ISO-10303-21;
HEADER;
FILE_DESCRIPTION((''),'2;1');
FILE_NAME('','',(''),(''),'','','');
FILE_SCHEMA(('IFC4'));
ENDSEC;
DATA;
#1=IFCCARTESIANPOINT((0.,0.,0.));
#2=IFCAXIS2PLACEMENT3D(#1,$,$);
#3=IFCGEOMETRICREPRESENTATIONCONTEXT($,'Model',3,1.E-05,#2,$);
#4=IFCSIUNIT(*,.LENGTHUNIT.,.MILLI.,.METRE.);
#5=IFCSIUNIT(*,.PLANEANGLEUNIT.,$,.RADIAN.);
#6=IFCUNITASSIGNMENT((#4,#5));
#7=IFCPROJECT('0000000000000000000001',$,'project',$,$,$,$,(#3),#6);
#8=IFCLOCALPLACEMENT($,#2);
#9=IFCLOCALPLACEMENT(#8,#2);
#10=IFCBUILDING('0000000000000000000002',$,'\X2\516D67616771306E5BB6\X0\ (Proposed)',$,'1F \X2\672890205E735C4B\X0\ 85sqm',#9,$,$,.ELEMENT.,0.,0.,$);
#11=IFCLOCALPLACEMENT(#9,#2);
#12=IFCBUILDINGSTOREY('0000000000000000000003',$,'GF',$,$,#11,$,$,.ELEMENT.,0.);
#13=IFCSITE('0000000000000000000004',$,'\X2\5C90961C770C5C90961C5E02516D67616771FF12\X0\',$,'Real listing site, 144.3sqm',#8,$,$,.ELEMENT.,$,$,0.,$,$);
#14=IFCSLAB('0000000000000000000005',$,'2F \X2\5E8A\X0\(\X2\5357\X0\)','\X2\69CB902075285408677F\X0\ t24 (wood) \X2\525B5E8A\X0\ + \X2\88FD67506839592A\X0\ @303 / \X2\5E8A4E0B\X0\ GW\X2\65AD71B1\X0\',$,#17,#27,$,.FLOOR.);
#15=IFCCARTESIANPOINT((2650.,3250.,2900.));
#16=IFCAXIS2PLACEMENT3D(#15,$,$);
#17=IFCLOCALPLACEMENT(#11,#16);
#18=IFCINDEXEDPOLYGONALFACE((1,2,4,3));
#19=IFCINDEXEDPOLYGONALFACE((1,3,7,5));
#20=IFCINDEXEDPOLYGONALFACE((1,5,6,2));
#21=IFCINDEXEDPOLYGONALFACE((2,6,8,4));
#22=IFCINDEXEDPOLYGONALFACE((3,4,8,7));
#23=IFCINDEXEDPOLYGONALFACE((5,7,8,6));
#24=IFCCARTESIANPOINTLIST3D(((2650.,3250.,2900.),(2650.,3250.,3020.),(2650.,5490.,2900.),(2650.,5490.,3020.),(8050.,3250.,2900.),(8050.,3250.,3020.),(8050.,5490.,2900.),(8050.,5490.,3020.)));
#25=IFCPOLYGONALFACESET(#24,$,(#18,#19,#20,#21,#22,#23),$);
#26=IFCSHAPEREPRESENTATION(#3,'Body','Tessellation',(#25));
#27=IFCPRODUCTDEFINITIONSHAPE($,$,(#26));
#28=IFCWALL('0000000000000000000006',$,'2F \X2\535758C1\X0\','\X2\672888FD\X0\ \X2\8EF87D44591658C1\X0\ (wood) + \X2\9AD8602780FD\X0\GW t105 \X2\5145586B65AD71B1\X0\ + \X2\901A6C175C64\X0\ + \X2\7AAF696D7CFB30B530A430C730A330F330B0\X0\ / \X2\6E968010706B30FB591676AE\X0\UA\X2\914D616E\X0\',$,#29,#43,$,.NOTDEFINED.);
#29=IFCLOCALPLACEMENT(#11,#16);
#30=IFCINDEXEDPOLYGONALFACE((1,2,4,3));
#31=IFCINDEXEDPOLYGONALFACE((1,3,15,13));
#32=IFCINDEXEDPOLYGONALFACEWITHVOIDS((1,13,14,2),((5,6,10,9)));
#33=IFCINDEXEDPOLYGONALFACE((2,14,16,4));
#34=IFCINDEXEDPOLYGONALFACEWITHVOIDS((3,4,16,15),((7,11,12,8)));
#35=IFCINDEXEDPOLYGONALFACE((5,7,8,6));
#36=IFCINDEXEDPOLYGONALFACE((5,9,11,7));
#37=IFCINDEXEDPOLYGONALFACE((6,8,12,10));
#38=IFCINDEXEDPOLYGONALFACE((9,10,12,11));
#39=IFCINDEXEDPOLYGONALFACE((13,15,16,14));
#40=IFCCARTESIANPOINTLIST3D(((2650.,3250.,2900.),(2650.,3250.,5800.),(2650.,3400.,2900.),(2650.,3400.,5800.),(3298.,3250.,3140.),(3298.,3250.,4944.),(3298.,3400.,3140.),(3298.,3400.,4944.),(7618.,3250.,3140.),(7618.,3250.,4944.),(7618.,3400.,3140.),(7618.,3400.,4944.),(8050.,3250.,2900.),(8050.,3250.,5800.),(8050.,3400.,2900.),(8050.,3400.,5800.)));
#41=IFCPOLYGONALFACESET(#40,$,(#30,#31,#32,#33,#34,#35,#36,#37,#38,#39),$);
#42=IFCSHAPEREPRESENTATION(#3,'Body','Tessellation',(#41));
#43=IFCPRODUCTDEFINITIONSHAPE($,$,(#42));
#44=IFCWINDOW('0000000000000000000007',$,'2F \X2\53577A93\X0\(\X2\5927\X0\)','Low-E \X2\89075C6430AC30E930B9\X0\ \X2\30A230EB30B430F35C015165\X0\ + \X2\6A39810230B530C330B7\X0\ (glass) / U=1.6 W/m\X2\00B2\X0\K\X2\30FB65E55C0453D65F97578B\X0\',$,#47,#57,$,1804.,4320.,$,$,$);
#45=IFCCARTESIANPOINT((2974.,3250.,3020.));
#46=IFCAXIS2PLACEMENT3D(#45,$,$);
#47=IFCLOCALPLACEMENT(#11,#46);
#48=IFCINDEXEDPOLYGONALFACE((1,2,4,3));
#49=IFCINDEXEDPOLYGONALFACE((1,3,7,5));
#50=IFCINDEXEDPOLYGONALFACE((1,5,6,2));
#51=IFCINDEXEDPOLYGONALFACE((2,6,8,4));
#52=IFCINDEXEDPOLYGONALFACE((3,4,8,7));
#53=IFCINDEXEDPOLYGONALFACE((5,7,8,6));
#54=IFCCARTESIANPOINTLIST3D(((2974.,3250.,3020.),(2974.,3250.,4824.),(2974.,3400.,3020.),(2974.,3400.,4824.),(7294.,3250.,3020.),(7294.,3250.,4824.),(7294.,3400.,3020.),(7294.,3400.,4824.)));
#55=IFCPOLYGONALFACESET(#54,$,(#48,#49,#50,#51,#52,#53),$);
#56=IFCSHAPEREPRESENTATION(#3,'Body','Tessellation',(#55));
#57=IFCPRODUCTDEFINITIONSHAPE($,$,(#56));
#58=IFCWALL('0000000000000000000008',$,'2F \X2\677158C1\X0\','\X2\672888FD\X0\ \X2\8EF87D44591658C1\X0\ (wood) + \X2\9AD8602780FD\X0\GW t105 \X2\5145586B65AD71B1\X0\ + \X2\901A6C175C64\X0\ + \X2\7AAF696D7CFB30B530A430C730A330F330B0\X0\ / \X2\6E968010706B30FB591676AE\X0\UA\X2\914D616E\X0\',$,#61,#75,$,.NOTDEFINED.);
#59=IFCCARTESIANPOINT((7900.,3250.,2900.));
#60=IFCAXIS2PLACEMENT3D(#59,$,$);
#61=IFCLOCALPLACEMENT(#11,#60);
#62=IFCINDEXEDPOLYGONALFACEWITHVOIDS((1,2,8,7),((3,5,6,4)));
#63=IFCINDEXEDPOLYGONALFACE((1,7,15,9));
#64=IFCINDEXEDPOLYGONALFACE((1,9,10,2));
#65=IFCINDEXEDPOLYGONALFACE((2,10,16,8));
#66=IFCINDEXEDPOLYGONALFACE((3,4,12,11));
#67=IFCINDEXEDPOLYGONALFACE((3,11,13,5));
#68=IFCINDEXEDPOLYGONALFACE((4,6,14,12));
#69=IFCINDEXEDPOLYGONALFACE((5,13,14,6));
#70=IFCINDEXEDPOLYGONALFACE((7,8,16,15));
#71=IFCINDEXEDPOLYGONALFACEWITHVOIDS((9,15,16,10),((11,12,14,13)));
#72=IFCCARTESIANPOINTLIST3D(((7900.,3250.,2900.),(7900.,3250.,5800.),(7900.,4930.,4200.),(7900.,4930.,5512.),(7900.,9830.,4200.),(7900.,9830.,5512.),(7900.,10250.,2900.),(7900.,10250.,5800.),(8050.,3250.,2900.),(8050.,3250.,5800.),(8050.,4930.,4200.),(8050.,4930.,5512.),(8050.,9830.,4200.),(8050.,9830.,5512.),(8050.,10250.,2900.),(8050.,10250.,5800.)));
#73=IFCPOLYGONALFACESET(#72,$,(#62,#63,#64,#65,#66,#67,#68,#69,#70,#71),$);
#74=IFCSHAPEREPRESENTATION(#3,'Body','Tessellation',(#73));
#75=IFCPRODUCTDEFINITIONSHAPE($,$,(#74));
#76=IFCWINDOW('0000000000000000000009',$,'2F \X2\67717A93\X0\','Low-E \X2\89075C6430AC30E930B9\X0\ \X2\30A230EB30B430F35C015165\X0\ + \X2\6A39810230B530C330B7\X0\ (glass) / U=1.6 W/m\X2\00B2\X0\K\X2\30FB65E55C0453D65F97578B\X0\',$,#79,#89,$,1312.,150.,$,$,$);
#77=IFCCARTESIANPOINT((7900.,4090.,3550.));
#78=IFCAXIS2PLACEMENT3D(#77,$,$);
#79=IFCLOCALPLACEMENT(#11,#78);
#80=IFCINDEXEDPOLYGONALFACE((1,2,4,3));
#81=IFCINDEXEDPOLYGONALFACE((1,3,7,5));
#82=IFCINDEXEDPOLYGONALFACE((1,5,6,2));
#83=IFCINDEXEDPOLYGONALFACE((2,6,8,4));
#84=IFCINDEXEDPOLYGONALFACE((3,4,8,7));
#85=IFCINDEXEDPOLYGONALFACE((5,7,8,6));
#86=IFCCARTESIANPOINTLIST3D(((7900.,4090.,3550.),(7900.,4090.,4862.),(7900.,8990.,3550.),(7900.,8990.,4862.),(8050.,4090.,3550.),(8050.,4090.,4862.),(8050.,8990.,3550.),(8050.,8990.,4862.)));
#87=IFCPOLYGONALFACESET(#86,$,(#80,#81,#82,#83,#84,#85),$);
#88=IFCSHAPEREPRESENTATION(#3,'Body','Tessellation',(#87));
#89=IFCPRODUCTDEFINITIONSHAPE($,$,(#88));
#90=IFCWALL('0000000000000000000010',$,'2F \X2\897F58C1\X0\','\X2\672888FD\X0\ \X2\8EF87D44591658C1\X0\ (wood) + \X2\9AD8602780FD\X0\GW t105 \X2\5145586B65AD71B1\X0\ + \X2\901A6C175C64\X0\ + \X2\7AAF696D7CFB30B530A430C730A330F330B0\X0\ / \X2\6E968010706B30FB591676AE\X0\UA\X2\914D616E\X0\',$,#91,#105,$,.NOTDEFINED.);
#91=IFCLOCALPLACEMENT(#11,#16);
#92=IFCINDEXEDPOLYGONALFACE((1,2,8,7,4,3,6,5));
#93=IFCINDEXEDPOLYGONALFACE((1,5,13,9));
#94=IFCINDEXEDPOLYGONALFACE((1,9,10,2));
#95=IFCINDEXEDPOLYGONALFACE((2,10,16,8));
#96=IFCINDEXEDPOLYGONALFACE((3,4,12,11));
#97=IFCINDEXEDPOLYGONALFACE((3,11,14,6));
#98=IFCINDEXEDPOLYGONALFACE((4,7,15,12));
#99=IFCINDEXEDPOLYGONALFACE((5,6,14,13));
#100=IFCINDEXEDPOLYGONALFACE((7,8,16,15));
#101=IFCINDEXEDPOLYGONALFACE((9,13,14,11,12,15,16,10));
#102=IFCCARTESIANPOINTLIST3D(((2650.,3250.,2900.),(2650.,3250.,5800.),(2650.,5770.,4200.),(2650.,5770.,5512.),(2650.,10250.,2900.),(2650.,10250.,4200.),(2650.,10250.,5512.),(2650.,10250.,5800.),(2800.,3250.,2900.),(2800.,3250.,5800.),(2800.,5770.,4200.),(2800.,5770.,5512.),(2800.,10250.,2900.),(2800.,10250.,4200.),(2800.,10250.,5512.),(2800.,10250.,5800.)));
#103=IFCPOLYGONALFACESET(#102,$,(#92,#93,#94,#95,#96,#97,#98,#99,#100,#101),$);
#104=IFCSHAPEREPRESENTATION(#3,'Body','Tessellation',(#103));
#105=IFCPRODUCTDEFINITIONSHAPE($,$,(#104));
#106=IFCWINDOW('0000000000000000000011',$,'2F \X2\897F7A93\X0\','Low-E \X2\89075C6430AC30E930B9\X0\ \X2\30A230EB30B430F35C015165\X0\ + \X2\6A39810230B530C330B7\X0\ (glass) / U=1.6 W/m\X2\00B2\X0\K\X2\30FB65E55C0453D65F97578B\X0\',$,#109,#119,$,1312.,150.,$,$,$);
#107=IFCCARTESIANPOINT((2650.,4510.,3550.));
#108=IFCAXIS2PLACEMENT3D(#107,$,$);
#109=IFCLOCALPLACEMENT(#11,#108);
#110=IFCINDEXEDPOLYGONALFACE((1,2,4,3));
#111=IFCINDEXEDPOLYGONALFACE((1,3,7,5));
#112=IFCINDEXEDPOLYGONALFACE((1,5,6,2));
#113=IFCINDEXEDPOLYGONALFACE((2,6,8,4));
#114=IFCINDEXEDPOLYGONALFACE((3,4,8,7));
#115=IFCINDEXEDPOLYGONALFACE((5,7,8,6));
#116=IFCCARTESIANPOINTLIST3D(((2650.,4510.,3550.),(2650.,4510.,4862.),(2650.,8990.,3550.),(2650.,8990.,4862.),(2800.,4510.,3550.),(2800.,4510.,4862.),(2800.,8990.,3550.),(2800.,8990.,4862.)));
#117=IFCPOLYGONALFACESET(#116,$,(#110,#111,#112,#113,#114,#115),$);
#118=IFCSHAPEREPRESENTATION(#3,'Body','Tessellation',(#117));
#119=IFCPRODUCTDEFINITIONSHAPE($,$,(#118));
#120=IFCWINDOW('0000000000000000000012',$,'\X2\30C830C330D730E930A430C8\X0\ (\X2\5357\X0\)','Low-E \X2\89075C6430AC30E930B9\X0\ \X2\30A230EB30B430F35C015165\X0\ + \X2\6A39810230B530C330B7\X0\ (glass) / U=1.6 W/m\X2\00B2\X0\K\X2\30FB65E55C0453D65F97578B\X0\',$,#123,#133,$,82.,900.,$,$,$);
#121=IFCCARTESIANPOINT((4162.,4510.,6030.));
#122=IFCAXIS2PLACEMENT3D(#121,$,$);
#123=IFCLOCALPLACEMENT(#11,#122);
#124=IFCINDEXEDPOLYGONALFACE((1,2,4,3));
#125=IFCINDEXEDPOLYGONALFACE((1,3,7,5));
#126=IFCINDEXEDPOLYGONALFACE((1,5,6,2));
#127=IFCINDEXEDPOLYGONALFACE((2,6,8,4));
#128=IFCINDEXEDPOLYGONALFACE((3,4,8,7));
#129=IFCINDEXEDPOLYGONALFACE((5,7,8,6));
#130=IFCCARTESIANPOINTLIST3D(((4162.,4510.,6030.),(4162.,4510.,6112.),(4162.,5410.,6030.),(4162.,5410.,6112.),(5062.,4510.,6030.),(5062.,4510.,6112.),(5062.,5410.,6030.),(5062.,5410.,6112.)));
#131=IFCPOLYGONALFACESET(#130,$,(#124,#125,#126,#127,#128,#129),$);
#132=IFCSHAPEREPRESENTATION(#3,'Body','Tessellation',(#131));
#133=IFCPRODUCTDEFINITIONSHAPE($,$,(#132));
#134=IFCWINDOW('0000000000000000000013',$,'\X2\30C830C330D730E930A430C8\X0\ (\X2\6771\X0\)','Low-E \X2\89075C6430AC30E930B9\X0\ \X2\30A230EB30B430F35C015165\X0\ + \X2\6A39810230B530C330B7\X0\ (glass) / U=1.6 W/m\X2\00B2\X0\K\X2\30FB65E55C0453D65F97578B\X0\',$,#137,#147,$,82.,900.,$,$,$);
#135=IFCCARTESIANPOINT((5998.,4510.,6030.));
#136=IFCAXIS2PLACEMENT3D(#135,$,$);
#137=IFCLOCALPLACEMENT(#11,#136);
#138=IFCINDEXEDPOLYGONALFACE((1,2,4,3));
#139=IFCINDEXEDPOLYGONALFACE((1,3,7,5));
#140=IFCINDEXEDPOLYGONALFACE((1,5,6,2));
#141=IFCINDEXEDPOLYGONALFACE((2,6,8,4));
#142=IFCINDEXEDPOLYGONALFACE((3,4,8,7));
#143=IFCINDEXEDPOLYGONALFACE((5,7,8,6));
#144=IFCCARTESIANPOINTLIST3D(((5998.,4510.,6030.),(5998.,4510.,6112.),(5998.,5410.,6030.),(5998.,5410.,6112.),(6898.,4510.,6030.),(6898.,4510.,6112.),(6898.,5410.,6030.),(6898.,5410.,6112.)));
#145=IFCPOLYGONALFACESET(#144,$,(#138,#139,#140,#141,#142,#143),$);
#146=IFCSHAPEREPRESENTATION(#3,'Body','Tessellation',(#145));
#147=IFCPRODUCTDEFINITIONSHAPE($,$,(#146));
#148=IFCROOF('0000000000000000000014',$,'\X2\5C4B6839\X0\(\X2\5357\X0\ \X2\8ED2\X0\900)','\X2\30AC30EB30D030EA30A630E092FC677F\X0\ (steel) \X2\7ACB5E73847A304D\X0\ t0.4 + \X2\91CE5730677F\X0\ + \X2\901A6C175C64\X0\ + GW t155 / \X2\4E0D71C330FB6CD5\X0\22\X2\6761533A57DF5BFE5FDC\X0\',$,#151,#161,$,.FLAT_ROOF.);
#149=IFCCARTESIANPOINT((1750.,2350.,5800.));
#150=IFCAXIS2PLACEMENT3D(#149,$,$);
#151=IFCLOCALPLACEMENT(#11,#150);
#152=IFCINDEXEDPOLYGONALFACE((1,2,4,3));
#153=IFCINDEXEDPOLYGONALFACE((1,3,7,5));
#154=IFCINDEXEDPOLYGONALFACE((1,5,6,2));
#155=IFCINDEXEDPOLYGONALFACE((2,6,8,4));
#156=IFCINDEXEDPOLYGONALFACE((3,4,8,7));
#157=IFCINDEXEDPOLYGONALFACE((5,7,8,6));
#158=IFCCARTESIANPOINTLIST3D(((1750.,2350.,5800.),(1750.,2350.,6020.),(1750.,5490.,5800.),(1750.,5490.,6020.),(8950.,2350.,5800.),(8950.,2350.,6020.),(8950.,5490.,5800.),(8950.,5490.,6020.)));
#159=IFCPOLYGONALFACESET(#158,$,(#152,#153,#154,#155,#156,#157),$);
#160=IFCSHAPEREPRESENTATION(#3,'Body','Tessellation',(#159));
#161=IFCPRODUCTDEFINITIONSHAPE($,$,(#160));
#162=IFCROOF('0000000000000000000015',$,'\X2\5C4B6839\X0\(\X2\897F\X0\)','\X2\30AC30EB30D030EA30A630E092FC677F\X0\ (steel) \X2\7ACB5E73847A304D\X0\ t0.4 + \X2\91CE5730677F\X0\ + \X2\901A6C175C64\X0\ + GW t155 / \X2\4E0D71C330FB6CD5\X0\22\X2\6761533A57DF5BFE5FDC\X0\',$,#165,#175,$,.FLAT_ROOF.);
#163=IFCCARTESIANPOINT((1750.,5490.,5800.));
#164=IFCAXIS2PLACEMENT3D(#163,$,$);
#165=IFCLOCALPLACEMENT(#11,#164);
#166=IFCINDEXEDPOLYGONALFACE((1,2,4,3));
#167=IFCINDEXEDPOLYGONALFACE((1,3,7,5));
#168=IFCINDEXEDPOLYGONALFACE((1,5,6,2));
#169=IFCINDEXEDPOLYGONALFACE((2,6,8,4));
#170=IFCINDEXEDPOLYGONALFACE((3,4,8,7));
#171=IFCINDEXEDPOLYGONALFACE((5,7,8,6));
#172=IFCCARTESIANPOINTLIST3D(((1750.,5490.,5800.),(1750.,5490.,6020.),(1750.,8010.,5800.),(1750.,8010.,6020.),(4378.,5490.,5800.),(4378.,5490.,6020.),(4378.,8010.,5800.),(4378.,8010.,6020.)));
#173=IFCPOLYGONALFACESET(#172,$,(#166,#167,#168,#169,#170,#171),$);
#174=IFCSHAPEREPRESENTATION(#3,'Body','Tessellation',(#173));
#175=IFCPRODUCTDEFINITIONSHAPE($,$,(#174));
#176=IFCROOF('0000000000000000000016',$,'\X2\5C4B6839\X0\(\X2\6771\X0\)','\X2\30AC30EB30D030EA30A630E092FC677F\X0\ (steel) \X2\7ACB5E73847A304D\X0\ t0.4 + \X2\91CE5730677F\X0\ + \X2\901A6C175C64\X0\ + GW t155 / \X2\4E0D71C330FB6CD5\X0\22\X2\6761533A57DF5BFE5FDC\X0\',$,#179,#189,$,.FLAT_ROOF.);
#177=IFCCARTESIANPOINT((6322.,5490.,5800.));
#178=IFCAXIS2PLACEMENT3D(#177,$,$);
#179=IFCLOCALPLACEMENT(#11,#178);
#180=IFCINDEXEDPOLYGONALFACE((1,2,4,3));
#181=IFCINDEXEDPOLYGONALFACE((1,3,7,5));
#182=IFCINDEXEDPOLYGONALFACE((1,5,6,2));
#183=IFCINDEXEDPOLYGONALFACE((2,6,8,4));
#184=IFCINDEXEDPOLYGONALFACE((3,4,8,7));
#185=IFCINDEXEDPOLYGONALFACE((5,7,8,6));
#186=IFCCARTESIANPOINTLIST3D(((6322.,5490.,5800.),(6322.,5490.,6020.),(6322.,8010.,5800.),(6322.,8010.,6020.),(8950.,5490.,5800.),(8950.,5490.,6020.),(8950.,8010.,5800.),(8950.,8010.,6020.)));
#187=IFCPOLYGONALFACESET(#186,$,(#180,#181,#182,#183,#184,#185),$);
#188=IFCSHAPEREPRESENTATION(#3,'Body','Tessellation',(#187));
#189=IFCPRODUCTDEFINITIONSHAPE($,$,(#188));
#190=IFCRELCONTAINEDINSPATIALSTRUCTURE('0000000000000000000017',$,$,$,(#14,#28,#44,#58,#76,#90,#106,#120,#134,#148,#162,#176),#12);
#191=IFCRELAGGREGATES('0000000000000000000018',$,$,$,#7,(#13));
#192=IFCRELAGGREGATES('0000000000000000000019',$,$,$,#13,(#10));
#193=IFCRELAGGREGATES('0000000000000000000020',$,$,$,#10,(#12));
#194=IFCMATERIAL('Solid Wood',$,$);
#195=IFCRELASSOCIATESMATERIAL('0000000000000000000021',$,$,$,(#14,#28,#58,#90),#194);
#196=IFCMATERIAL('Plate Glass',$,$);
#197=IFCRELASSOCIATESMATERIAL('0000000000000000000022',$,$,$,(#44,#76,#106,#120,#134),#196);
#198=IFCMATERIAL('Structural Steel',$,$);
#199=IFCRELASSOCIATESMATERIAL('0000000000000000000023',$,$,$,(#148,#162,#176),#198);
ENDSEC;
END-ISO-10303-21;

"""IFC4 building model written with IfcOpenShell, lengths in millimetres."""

from ifc_helpers import new_model, si_unit, frame, frame_2d, origin, place, context, project, spatial, rectangle, extrude, material, element, fill, save


model = new_model("IFC4")

# Units and contexts
model_context = context("Model", 3, precision=1e-05, world=origin())
ifc_project = project(units=[si_unit("LENGTHUNIT", "METRE", prefix="MILLI"), si_unit("PLANEANGLEUNIT", "RADIAN")], contexts=[model_context])

# Site, building, storey
site_placement = place(None, origin())
site = spatial("IfcSite", under=ifc_project, at=site_placement, Name="岐阜県岐阜市六条東２", ObjectType="Real listing site, 144.3sqm", CompositionType="ELEMENT", RefElevation=0.0)
building_placement = place(site_placement, origin())
building = spatial("IfcBuilding", under=site, at=building_placement, Name="六条東の家 (Proposed)", ObjectType="1F 木造平屋 85sqm", CompositionType="ELEMENT", ElevationOfRefHeight=0.0, ElevationOfTerrain=0.0)
storey_placement = place(building_placement, origin())
storey = spatial("IfcBuildingStorey", under=building, at=storey_placement, Name="GF", CompositionType="ELEMENT", Elevation=0.0)

# Slab
ifc_material_1 = material(Name="Solid Wood")
slab_placement = place(storey_placement, frame((2650.0, 3250.0, 2900.0)))
element("IfcSlab", 1, at=slab_placement, inside=storey, material=ifc_material_1, Name="2F 床(南)", Description="構造用合板 t24 (wood) 剛床 + 製材根太 @303 / 床下 GW断熱", PredefinedType="FLOOR", context=model_context, shape_type="SweptSolid", body=[
    extrude(rectangle(XDim=5400.0, YDim=2240.0, at=frame_2d((2700.0, 1120.0))), frame((2650.0, 3250.0, 2900.0)), (0.0, 0.0, 1.0), 120.0),
])

# Walls, openings, windows
wall_1_placement = place(storey_placement, frame((2650.0, 3250.0, 2900.0)))
wall_1 = element("IfcWall", 2, at=wall_1_placement, inside=storey, material=ifc_material_1, Name="2F 南壁", Description="木製 軸組外壁 (wood) + 高性能GW t105 充填断熱 + 通気層 + 窯業系サイディング / 準耐火・外皮UA配慮", PredefinedType="NOTDEFINED", context=model_context, shape_type="SweptSolid", body=[
    extrude(rectangle(XDim=5400.0, YDim=150.0, at=frame_2d((2700.0, 75.0))), frame((2650.0, 3250.0, 2900.0)), (0.0, 0.0, 1.0), 2900.0),
])
opening_1_placement = place(storey_placement, frame((2974.0, 3250.0, 3020.0)))
opening_1 = element("IfcOpeningElement", 3, at=opening_1_placement, cuts=wall_1, PredefinedType="NOTDEFINED", context=model_context, shape_type="SweptSolid", body=[
    extrude(rectangle(XDim=4320.0, YDim=150.0, at=frame_2d((2160.0, 75.0))), frame((2974.0, 3250.0, 3020.0)), (0.0, 0.0, 1.0), 1804.0),
])
ifc_material_2 = material(Name="Plate Glass")
window_1_placement = place(storey_placement, frame((2974.0, 3250.0, 3020.0)))
window_1 = element("IfcWindow", 4, at=window_1_placement, inside=storey, material=ifc_material_2, Name="2F 南窓(大)", Description="Low-E 複層ガラス アルゴン封入 + 樹脂サッシ (glass) / U=1.6 W/m²K・日射取得型", OverallHeight=1804.0, OverallWidth=4320.0, context=model_context, shape_type="SweptSolid", body=[
    extrude(rectangle(XDim=4320.0, YDim=150.0, at=frame_2d((2160.0, 75.0))), frame((2974.0, 3250.0, 3020.0)), (0.0, 0.0, 1.0), 1804.0),
])
fill(opening_1, window_1)
wall_2_placement = place(storey_placement, frame((7900.0, 3250.0, 2900.0)))
wall_2 = element("IfcWall", 5, at=wall_2_placement, inside=storey, material=ifc_material_1, Name="2F 東壁", Description="木製 軸組外壁 (wood) + 高性能GW t105 充填断熱 + 通気層 + 窯業系サイディング / 準耐火・外皮UA配慮", PredefinedType="NOTDEFINED", context=model_context, shape_type="SweptSolid", body=[
    extrude(rectangle(XDim=150.0, YDim=7000.0, at=frame_2d((75.0, 3500.0))), frame((7900.0, 3250.0, 2900.0)), (0.0, 0.0, 1.0), 2900.0),
])
opening_2_placement = place(storey_placement, frame((7900.0, 4090.0, 3550.0)))
opening_2 = element("IfcOpeningElement", 6, at=opening_2_placement, cuts=wall_2, PredefinedType="NOTDEFINED", context=model_context, shape_type="SweptSolid", body=[
    extrude(rectangle(XDim=150.0, YDim=4900.0, at=frame_2d((75.0, 2450.0))), frame((7900.0, 4090.0, 3550.0)), (0.0, 0.0, 1.0), 1312.0),
])
window_2_placement = place(storey_placement, frame((7900.0, 4090.0, 3550.0)))
window_2 = element("IfcWindow", 7, at=window_2_placement, inside=storey, material=ifc_material_2, Name="2F 東窓", Description="Low-E 複層ガラス アルゴン封入 + 樹脂サッシ (glass) / U=1.6 W/m²K・日射取得型", OverallHeight=1312.0, OverallWidth=150.0, context=model_context, shape_type="SweptSolid", body=[
    extrude(rectangle(XDim=150.0, YDim=4900.0, at=frame_2d((75.0, 2450.0))), frame((7900.0, 4090.0, 3550.0)), (0.0, 0.0, 1.0), 1312.0),
])
fill(opening_2, window_2)
wall_3_placement = place(storey_placement, frame((2650.0, 3250.0, 2900.0)))
wall_3 = element("IfcWall", 8, at=wall_3_placement, inside=storey, material=ifc_material_1, Name="2F 西壁", Description="木製 軸組外壁 (wood) + 高性能GW t105 充填断熱 + 通気層 + 窯業系サイディング / 準耐火・外皮UA配慮", PredefinedType="NOTDEFINED", context=model_context, shape_type="SweptSolid", body=[
    extrude(rectangle(XDim=150.0, YDim=7000.0, at=frame_2d((75.0, 3500.0))), frame((2650.0, 3250.0, 2900.0)), (0.0, 0.0, 1.0), 2900.0),
])
opening_3_placement = place(storey_placement, frame((2650.0, 4510.0, 3550.0)))
opening_3 = element("IfcOpeningElement", 9, at=opening_3_placement, cuts=wall_3, PredefinedType="NOTDEFINED", context=model_context, shape_type="SweptSolid", body=[
    extrude(rectangle(XDim=150.0, YDim=4480.0, at=frame_2d((75.0, 2240.0))), frame((2650.0, 4510.0, 3550.0)), (0.0, 0.0, 1.0), 1312.0),
])
window_3_placement = place(storey_placement, frame((2650.0, 4510.0, 3550.0)))
window_3 = element("IfcWindow", 10, at=window_3_placement, inside=storey, material=ifc_material_2, Name="2F 西窓", Description="Low-E 複層ガラス アルゴン封入 + 樹脂サッシ (glass) / U=1.6 W/m²K・日射取得型", OverallHeight=1312.0, OverallWidth=150.0, context=model_context, shape_type="SweptSolid", body=[
    extrude(rectangle(XDim=150.0, YDim=4480.0, at=frame_2d((75.0, 2240.0))), frame((2650.0, 4510.0, 3550.0)), (0.0, 0.0, 1.0), 1312.0),
])
fill(opening_3, window_3)

# Windows
window_4_placement = place(storey_placement, frame((4162.0, 4510.0, 6030.0)))
element("IfcWindow", 11, at=window_4_placement, inside=storey, material=ifc_material_2, Name="トップライト (南)", Description="Low-E 複層ガラス アルゴン封入 + 樹脂サッシ (glass) / U=1.6 W/m²K・日射取得型", OverallHeight=82.0, OverallWidth=900.0, context=model_context, shape_type="SweptSolid", body=[
    extrude(rectangle(XDim=900.0, YDim=900.0, at=frame_2d((450.0, 450.0))), frame((4162.0, 4510.0, 6030.0)), (0.0, 0.0, 1.0), 82.0),
])
window_5_placement = place(storey_placement, frame((5998.0, 4510.0, 6030.0)))
element("IfcWindow", 12, at=window_5_placement, inside=storey, material=ifc_material_2, Name="トップライト (東)", Description="Low-E 複層ガラス アルゴン封入 + 樹脂サッシ (glass) / U=1.6 W/m²K・日射取得型", OverallHeight=82.0, OverallWidth=900.0, context=model_context, shape_type="SweptSolid", body=[
    extrude(rectangle(XDim=900.0, YDim=900.0, at=frame_2d((450.0, 450.0))), frame((5998.0, 4510.0, 6030.0)), (0.0, 0.0, 1.0), 82.0),
])

# Roofs
ifc_material_3 = material(Name="Structural Steel")
roof_1_placement = place(storey_placement, frame((1750.0, 2350.0, 5800.0)))
element("IfcRoof", 13, at=roof_1_placement, inside=storey, material=ifc_material_3, Name="屋根(南 軒900)", Description="ガルバリウム鋼板 (steel) 立平葺き t0.4 + 野地板 + 通気層 + GW t155 / 不燃・法22条区域対応", PredefinedType="FLAT_ROOF", context=model_context, shape_type="SweptSolid", body=[
    extrude(rectangle(XDim=7200.0, YDim=3140.0, at=frame_2d((3600.0, 1570.0))), frame((1750.0, 2350.0, 5800.0)), (0.0, 0.0, 1.0), 220.0),
])
roof_2_placement = place(storey_placement, frame((1750.0, 5490.0, 5800.0)))
element("IfcRoof", 14, at=roof_2_placement, inside=storey, material=ifc_material_3, Name="屋根(西)", Description="ガルバリウム鋼板 (steel) 立平葺き t0.4 + 野地板 + 通気層 + GW t155 / 不燃・法22条区域対応", PredefinedType="FLAT_ROOF", context=model_context, shape_type="SweptSolid", body=[
    extrude(rectangle(XDim=2628.0, YDim=2520.0, at=frame_2d((1314.0, 1260.0))), frame((1750.0, 5490.0, 5800.0)), (0.0, 0.0, 1.0), 220.0),
])
roof_3_placement = place(storey_placement, frame((6322.0, 5490.0, 5800.0)))
element("IfcRoof", 15, at=roof_3_placement, inside=storey, material=ifc_material_3, Name="屋根(東)", Description="ガルバリウム鋼板 (steel) 立平葺き t0.4 + 野地板 + 通気層 + GW t155 / 不燃・法22条区域対応", PredefinedType="FLAT_ROOF", context=model_context, shape_type="SweptSolid", body=[
    extrude(rectangle(XDim=2628.0, YDim=2520.0, at=frame_2d((1314.0, 1260.0))), frame((6322.0, 5490.0, 5800.0)), (0.0, 0.0, 1.0), 220.0),
])

save(model, "model.ifc")
